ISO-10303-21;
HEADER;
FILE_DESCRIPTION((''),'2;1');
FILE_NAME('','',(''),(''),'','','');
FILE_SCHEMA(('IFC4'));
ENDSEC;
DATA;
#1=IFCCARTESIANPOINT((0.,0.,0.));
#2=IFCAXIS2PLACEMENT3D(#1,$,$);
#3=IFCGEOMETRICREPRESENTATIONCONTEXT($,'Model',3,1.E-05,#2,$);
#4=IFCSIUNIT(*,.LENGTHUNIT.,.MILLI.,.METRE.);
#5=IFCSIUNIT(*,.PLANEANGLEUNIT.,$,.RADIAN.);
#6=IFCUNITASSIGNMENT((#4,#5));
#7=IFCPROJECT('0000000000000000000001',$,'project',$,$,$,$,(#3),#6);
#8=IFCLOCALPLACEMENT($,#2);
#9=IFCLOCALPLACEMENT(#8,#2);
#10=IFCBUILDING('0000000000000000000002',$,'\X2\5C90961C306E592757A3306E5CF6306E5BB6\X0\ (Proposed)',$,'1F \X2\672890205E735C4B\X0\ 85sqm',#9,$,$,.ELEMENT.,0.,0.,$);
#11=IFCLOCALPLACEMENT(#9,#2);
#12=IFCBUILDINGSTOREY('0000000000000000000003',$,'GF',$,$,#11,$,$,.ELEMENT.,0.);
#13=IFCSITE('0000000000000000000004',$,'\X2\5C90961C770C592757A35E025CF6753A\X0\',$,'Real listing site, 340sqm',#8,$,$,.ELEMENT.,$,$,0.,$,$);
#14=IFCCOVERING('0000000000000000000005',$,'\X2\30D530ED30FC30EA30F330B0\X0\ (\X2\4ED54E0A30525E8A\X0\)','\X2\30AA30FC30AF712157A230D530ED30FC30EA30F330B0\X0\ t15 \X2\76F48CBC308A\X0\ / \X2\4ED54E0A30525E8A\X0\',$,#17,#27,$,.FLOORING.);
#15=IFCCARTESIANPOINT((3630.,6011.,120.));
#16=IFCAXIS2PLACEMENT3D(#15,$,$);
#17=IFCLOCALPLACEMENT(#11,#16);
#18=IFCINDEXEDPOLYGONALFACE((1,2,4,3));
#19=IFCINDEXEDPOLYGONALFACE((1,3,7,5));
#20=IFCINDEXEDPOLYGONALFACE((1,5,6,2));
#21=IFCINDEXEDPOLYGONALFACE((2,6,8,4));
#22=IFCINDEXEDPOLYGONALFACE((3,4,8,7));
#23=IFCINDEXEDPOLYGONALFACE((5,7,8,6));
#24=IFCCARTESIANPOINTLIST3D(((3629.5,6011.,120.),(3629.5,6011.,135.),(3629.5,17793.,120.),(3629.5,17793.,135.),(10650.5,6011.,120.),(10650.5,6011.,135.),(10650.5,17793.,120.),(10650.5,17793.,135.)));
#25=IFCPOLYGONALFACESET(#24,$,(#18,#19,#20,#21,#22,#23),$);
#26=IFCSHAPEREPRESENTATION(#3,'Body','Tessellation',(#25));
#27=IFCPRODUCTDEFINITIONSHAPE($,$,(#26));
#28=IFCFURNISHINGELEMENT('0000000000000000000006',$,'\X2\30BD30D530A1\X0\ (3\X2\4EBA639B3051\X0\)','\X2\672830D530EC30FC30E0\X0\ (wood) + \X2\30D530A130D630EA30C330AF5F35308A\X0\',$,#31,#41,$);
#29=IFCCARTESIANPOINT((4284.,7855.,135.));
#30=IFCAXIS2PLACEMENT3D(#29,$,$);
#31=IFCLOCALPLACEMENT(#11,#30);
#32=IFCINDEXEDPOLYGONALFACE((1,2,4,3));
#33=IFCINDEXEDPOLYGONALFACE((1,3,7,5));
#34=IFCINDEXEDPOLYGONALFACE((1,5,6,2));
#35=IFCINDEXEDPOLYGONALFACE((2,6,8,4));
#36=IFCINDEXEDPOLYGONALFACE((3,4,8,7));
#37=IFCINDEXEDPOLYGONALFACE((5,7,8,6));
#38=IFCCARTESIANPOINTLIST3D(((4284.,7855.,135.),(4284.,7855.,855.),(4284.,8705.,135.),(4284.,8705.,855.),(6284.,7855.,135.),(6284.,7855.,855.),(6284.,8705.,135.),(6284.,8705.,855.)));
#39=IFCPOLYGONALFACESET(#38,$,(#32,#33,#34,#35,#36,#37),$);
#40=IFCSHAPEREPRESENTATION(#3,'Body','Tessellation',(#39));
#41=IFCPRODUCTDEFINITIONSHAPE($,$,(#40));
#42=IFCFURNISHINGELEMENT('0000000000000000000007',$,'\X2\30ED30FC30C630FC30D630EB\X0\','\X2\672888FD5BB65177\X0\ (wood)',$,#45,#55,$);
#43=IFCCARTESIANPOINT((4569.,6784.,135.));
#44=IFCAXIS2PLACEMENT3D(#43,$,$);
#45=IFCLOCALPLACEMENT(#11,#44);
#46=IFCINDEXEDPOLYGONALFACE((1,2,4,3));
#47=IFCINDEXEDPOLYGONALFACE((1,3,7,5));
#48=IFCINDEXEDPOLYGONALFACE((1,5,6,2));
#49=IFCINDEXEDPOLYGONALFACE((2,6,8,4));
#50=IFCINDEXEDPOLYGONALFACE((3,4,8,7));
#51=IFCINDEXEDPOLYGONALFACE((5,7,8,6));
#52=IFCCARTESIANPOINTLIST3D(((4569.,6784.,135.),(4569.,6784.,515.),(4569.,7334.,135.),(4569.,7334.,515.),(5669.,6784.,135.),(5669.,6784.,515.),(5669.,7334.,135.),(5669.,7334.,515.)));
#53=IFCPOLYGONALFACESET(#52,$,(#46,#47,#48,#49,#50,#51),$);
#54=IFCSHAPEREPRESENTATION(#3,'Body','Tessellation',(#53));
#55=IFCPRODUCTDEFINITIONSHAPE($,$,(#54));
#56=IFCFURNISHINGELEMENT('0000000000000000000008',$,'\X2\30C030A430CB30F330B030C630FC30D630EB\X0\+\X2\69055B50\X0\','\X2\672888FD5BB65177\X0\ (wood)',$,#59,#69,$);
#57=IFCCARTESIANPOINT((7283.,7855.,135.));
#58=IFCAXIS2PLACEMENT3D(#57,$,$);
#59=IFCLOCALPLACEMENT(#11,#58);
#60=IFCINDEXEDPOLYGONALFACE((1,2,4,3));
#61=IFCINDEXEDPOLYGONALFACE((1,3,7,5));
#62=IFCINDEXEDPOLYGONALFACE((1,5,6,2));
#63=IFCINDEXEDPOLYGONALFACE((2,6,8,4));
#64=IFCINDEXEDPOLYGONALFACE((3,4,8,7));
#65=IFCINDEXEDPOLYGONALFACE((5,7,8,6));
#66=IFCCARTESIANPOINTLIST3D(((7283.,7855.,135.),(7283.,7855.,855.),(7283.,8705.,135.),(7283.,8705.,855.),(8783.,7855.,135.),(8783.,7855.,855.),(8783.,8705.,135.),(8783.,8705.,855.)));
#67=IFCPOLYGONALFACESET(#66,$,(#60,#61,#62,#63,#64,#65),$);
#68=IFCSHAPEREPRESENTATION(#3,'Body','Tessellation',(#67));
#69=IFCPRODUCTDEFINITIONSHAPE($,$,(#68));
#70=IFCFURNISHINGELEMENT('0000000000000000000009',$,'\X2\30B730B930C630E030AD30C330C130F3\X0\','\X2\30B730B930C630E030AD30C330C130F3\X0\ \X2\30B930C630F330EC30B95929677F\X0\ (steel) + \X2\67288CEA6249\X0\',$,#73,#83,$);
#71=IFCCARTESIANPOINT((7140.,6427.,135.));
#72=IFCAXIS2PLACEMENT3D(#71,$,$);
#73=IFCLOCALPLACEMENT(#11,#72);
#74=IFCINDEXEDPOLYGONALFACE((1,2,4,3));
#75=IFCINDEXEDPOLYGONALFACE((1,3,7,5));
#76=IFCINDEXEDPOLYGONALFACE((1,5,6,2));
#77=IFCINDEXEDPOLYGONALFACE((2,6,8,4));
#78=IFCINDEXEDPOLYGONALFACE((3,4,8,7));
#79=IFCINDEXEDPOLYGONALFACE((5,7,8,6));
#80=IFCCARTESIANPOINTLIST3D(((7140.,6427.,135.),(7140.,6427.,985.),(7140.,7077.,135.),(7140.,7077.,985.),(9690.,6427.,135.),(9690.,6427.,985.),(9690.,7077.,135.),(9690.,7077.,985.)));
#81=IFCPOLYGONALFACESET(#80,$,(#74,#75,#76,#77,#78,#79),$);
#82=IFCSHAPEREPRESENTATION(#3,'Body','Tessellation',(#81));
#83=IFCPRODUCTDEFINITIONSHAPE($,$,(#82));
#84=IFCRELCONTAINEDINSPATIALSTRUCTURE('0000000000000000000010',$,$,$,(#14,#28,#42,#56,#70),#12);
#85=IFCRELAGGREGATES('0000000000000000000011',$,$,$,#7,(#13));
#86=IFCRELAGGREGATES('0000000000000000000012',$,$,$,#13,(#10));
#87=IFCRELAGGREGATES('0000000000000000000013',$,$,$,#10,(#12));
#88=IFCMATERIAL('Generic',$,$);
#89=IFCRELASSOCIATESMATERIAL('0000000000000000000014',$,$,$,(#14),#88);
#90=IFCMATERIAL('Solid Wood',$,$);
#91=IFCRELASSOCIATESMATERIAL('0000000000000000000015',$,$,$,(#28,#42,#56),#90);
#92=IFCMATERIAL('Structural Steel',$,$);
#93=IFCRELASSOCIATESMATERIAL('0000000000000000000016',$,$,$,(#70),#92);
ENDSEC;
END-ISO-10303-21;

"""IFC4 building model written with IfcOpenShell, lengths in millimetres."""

from ifc_helpers import new_model, si_unit, frame, frame_2d, origin, place, context, project, spatial, rectangle, extrude, material, element, save


model = new_model("IFC4")

# Units and contexts
model_context = context("Model", 3, precision=1e-05, world=origin())
ifc_project = project(units=[si_unit("LENGTHUNIT", "METRE", prefix="MILLI"), si_unit("PLANEANGLEUNIT", "RADIAN")], contexts=[model_context])

# Site, building, storey
site_placement = place(None, origin())
site = spatial("IfcSite", under=ifc_project, at=site_placement, Name="岐阜県大垣市島町", ObjectType="Real listing site, 340sqm", CompositionType="ELEMENT", RefElevation=0.0)
building_placement = place(site_placement, origin())
building = spatial("IfcBuilding", under=site, at=building_placement, Name="岐阜の大垣の島の家 (Proposed)", ObjectType="1F 木造平屋 85sqm", CompositionType="ELEMENT", ElevationOfRefHeight=0.0, ElevationOfTerrain=0.0)
storey_placement = place(building_placement, origin())
storey = spatial("IfcBuildingStorey", under=building, at=storey_placement, Name="GF", CompositionType="ELEMENT", Elevation=0.0)

# Shared definitions
ifc_material_1 = material(Name="Solid Wood")

# Shared definitions
ifc_material_2 = material(Name="Structural Steel")

# Covering
ifc_material_3 = material(Name="Generic")
covering_placement = place(storey_placement, frame((3630.0, 6011.0, 120.0)))
element("IfcCovering", 1, at=covering_placement, inside=storey, material=ifc_material_3, Name="フローリング (仕上げ床)", Description="オーク無垢フローリング t15 直貼り / 仕上げ床", PredefinedType="FLOORING", context=model_context, shape_type="SweptSolid", body=[
    extrude(rectangle(XDim=7021.0, YDim=11782.0, at=frame_2d((3510.0, 5891.0))), frame((3630.0, 6011.0, 120.0)), (0.0, 0.0, 1.0), 15.0),
])

# Furnishing elements
furnishing_1_placement = place(storey_placement, frame((4284.0, 7855.0, 135.0)))
element("IfcFurnishingElement", 2, at=furnishing_1_placement, inside=storey, material=ifc_material_1, Name="ソファ (3人掛け)", Description="木フレーム (wood) + ファブリック張り", context=model_context, shape_type="SweptSolid", body=[
    extrude(rectangle(XDim=2000.0, YDim=850.0, at=frame_2d((1000.0, 425.0))), frame((4284.0, 7855.0, 135.0)), (0.0, 0.0, 1.0), 720.0),
])
furnishing_2_placement = place(storey_placement, frame((4569.0, 6784.0, 135.0)))
element("IfcFurnishingElement", 3, at=furnishing_2_placement, inside=storey, material=ifc_material_1, Name="ローテーブル", Description="木製家具 (wood)", context=model_context, shape_type="SweptSolid", body=[
    extrude(rectangle(XDim=1100.0, YDim=550.0, at=frame_2d((550.0, 275.0))), frame((4569.0, 6784.0, 135.0)), (0.0, 0.0, 1.0), 380.0),
])
furnishing_3_placement = place(storey_placement, frame((7283.0, 7855.0, 135.0)))
element("IfcFurnishingElement", 4, at=furnishing_3_placement, inside=storey, material=ifc_material_1, Name="ダイニングテーブル+椅子", Description="木製家具 (wood)", context=model_context, shape_type="SweptSolid", body=[
    extrude(rectangle(XDim=1500.0, YDim=850.0, at=frame_2d((750.0, 425.0))), frame((7283.0, 7855.0, 135.0)), (0.0, 0.0, 1.0), 720.0),
])
furnishing_4_placement = place(storey_placement, frame((7140.0, 6427.0, 135.0)))
element("IfcFurnishingElement", 5, at=furnishing_4_placement, inside=storey, material=ifc_material_2, Name="システムキッチン", Description="システムキッチン ステンレス天板 (steel) + 木質扉", context=model_context, shape_type="SweptSolid", body=[
    extrude(rectangle(XDim=2550.0, YDim=650.0, at=frame_2d((1275.0, 325.0))), frame((7140.0, 6427.0, 135.0)), (0.0, 0.0, 1.0), 850.0),
])

save(model, "model.ifc")
